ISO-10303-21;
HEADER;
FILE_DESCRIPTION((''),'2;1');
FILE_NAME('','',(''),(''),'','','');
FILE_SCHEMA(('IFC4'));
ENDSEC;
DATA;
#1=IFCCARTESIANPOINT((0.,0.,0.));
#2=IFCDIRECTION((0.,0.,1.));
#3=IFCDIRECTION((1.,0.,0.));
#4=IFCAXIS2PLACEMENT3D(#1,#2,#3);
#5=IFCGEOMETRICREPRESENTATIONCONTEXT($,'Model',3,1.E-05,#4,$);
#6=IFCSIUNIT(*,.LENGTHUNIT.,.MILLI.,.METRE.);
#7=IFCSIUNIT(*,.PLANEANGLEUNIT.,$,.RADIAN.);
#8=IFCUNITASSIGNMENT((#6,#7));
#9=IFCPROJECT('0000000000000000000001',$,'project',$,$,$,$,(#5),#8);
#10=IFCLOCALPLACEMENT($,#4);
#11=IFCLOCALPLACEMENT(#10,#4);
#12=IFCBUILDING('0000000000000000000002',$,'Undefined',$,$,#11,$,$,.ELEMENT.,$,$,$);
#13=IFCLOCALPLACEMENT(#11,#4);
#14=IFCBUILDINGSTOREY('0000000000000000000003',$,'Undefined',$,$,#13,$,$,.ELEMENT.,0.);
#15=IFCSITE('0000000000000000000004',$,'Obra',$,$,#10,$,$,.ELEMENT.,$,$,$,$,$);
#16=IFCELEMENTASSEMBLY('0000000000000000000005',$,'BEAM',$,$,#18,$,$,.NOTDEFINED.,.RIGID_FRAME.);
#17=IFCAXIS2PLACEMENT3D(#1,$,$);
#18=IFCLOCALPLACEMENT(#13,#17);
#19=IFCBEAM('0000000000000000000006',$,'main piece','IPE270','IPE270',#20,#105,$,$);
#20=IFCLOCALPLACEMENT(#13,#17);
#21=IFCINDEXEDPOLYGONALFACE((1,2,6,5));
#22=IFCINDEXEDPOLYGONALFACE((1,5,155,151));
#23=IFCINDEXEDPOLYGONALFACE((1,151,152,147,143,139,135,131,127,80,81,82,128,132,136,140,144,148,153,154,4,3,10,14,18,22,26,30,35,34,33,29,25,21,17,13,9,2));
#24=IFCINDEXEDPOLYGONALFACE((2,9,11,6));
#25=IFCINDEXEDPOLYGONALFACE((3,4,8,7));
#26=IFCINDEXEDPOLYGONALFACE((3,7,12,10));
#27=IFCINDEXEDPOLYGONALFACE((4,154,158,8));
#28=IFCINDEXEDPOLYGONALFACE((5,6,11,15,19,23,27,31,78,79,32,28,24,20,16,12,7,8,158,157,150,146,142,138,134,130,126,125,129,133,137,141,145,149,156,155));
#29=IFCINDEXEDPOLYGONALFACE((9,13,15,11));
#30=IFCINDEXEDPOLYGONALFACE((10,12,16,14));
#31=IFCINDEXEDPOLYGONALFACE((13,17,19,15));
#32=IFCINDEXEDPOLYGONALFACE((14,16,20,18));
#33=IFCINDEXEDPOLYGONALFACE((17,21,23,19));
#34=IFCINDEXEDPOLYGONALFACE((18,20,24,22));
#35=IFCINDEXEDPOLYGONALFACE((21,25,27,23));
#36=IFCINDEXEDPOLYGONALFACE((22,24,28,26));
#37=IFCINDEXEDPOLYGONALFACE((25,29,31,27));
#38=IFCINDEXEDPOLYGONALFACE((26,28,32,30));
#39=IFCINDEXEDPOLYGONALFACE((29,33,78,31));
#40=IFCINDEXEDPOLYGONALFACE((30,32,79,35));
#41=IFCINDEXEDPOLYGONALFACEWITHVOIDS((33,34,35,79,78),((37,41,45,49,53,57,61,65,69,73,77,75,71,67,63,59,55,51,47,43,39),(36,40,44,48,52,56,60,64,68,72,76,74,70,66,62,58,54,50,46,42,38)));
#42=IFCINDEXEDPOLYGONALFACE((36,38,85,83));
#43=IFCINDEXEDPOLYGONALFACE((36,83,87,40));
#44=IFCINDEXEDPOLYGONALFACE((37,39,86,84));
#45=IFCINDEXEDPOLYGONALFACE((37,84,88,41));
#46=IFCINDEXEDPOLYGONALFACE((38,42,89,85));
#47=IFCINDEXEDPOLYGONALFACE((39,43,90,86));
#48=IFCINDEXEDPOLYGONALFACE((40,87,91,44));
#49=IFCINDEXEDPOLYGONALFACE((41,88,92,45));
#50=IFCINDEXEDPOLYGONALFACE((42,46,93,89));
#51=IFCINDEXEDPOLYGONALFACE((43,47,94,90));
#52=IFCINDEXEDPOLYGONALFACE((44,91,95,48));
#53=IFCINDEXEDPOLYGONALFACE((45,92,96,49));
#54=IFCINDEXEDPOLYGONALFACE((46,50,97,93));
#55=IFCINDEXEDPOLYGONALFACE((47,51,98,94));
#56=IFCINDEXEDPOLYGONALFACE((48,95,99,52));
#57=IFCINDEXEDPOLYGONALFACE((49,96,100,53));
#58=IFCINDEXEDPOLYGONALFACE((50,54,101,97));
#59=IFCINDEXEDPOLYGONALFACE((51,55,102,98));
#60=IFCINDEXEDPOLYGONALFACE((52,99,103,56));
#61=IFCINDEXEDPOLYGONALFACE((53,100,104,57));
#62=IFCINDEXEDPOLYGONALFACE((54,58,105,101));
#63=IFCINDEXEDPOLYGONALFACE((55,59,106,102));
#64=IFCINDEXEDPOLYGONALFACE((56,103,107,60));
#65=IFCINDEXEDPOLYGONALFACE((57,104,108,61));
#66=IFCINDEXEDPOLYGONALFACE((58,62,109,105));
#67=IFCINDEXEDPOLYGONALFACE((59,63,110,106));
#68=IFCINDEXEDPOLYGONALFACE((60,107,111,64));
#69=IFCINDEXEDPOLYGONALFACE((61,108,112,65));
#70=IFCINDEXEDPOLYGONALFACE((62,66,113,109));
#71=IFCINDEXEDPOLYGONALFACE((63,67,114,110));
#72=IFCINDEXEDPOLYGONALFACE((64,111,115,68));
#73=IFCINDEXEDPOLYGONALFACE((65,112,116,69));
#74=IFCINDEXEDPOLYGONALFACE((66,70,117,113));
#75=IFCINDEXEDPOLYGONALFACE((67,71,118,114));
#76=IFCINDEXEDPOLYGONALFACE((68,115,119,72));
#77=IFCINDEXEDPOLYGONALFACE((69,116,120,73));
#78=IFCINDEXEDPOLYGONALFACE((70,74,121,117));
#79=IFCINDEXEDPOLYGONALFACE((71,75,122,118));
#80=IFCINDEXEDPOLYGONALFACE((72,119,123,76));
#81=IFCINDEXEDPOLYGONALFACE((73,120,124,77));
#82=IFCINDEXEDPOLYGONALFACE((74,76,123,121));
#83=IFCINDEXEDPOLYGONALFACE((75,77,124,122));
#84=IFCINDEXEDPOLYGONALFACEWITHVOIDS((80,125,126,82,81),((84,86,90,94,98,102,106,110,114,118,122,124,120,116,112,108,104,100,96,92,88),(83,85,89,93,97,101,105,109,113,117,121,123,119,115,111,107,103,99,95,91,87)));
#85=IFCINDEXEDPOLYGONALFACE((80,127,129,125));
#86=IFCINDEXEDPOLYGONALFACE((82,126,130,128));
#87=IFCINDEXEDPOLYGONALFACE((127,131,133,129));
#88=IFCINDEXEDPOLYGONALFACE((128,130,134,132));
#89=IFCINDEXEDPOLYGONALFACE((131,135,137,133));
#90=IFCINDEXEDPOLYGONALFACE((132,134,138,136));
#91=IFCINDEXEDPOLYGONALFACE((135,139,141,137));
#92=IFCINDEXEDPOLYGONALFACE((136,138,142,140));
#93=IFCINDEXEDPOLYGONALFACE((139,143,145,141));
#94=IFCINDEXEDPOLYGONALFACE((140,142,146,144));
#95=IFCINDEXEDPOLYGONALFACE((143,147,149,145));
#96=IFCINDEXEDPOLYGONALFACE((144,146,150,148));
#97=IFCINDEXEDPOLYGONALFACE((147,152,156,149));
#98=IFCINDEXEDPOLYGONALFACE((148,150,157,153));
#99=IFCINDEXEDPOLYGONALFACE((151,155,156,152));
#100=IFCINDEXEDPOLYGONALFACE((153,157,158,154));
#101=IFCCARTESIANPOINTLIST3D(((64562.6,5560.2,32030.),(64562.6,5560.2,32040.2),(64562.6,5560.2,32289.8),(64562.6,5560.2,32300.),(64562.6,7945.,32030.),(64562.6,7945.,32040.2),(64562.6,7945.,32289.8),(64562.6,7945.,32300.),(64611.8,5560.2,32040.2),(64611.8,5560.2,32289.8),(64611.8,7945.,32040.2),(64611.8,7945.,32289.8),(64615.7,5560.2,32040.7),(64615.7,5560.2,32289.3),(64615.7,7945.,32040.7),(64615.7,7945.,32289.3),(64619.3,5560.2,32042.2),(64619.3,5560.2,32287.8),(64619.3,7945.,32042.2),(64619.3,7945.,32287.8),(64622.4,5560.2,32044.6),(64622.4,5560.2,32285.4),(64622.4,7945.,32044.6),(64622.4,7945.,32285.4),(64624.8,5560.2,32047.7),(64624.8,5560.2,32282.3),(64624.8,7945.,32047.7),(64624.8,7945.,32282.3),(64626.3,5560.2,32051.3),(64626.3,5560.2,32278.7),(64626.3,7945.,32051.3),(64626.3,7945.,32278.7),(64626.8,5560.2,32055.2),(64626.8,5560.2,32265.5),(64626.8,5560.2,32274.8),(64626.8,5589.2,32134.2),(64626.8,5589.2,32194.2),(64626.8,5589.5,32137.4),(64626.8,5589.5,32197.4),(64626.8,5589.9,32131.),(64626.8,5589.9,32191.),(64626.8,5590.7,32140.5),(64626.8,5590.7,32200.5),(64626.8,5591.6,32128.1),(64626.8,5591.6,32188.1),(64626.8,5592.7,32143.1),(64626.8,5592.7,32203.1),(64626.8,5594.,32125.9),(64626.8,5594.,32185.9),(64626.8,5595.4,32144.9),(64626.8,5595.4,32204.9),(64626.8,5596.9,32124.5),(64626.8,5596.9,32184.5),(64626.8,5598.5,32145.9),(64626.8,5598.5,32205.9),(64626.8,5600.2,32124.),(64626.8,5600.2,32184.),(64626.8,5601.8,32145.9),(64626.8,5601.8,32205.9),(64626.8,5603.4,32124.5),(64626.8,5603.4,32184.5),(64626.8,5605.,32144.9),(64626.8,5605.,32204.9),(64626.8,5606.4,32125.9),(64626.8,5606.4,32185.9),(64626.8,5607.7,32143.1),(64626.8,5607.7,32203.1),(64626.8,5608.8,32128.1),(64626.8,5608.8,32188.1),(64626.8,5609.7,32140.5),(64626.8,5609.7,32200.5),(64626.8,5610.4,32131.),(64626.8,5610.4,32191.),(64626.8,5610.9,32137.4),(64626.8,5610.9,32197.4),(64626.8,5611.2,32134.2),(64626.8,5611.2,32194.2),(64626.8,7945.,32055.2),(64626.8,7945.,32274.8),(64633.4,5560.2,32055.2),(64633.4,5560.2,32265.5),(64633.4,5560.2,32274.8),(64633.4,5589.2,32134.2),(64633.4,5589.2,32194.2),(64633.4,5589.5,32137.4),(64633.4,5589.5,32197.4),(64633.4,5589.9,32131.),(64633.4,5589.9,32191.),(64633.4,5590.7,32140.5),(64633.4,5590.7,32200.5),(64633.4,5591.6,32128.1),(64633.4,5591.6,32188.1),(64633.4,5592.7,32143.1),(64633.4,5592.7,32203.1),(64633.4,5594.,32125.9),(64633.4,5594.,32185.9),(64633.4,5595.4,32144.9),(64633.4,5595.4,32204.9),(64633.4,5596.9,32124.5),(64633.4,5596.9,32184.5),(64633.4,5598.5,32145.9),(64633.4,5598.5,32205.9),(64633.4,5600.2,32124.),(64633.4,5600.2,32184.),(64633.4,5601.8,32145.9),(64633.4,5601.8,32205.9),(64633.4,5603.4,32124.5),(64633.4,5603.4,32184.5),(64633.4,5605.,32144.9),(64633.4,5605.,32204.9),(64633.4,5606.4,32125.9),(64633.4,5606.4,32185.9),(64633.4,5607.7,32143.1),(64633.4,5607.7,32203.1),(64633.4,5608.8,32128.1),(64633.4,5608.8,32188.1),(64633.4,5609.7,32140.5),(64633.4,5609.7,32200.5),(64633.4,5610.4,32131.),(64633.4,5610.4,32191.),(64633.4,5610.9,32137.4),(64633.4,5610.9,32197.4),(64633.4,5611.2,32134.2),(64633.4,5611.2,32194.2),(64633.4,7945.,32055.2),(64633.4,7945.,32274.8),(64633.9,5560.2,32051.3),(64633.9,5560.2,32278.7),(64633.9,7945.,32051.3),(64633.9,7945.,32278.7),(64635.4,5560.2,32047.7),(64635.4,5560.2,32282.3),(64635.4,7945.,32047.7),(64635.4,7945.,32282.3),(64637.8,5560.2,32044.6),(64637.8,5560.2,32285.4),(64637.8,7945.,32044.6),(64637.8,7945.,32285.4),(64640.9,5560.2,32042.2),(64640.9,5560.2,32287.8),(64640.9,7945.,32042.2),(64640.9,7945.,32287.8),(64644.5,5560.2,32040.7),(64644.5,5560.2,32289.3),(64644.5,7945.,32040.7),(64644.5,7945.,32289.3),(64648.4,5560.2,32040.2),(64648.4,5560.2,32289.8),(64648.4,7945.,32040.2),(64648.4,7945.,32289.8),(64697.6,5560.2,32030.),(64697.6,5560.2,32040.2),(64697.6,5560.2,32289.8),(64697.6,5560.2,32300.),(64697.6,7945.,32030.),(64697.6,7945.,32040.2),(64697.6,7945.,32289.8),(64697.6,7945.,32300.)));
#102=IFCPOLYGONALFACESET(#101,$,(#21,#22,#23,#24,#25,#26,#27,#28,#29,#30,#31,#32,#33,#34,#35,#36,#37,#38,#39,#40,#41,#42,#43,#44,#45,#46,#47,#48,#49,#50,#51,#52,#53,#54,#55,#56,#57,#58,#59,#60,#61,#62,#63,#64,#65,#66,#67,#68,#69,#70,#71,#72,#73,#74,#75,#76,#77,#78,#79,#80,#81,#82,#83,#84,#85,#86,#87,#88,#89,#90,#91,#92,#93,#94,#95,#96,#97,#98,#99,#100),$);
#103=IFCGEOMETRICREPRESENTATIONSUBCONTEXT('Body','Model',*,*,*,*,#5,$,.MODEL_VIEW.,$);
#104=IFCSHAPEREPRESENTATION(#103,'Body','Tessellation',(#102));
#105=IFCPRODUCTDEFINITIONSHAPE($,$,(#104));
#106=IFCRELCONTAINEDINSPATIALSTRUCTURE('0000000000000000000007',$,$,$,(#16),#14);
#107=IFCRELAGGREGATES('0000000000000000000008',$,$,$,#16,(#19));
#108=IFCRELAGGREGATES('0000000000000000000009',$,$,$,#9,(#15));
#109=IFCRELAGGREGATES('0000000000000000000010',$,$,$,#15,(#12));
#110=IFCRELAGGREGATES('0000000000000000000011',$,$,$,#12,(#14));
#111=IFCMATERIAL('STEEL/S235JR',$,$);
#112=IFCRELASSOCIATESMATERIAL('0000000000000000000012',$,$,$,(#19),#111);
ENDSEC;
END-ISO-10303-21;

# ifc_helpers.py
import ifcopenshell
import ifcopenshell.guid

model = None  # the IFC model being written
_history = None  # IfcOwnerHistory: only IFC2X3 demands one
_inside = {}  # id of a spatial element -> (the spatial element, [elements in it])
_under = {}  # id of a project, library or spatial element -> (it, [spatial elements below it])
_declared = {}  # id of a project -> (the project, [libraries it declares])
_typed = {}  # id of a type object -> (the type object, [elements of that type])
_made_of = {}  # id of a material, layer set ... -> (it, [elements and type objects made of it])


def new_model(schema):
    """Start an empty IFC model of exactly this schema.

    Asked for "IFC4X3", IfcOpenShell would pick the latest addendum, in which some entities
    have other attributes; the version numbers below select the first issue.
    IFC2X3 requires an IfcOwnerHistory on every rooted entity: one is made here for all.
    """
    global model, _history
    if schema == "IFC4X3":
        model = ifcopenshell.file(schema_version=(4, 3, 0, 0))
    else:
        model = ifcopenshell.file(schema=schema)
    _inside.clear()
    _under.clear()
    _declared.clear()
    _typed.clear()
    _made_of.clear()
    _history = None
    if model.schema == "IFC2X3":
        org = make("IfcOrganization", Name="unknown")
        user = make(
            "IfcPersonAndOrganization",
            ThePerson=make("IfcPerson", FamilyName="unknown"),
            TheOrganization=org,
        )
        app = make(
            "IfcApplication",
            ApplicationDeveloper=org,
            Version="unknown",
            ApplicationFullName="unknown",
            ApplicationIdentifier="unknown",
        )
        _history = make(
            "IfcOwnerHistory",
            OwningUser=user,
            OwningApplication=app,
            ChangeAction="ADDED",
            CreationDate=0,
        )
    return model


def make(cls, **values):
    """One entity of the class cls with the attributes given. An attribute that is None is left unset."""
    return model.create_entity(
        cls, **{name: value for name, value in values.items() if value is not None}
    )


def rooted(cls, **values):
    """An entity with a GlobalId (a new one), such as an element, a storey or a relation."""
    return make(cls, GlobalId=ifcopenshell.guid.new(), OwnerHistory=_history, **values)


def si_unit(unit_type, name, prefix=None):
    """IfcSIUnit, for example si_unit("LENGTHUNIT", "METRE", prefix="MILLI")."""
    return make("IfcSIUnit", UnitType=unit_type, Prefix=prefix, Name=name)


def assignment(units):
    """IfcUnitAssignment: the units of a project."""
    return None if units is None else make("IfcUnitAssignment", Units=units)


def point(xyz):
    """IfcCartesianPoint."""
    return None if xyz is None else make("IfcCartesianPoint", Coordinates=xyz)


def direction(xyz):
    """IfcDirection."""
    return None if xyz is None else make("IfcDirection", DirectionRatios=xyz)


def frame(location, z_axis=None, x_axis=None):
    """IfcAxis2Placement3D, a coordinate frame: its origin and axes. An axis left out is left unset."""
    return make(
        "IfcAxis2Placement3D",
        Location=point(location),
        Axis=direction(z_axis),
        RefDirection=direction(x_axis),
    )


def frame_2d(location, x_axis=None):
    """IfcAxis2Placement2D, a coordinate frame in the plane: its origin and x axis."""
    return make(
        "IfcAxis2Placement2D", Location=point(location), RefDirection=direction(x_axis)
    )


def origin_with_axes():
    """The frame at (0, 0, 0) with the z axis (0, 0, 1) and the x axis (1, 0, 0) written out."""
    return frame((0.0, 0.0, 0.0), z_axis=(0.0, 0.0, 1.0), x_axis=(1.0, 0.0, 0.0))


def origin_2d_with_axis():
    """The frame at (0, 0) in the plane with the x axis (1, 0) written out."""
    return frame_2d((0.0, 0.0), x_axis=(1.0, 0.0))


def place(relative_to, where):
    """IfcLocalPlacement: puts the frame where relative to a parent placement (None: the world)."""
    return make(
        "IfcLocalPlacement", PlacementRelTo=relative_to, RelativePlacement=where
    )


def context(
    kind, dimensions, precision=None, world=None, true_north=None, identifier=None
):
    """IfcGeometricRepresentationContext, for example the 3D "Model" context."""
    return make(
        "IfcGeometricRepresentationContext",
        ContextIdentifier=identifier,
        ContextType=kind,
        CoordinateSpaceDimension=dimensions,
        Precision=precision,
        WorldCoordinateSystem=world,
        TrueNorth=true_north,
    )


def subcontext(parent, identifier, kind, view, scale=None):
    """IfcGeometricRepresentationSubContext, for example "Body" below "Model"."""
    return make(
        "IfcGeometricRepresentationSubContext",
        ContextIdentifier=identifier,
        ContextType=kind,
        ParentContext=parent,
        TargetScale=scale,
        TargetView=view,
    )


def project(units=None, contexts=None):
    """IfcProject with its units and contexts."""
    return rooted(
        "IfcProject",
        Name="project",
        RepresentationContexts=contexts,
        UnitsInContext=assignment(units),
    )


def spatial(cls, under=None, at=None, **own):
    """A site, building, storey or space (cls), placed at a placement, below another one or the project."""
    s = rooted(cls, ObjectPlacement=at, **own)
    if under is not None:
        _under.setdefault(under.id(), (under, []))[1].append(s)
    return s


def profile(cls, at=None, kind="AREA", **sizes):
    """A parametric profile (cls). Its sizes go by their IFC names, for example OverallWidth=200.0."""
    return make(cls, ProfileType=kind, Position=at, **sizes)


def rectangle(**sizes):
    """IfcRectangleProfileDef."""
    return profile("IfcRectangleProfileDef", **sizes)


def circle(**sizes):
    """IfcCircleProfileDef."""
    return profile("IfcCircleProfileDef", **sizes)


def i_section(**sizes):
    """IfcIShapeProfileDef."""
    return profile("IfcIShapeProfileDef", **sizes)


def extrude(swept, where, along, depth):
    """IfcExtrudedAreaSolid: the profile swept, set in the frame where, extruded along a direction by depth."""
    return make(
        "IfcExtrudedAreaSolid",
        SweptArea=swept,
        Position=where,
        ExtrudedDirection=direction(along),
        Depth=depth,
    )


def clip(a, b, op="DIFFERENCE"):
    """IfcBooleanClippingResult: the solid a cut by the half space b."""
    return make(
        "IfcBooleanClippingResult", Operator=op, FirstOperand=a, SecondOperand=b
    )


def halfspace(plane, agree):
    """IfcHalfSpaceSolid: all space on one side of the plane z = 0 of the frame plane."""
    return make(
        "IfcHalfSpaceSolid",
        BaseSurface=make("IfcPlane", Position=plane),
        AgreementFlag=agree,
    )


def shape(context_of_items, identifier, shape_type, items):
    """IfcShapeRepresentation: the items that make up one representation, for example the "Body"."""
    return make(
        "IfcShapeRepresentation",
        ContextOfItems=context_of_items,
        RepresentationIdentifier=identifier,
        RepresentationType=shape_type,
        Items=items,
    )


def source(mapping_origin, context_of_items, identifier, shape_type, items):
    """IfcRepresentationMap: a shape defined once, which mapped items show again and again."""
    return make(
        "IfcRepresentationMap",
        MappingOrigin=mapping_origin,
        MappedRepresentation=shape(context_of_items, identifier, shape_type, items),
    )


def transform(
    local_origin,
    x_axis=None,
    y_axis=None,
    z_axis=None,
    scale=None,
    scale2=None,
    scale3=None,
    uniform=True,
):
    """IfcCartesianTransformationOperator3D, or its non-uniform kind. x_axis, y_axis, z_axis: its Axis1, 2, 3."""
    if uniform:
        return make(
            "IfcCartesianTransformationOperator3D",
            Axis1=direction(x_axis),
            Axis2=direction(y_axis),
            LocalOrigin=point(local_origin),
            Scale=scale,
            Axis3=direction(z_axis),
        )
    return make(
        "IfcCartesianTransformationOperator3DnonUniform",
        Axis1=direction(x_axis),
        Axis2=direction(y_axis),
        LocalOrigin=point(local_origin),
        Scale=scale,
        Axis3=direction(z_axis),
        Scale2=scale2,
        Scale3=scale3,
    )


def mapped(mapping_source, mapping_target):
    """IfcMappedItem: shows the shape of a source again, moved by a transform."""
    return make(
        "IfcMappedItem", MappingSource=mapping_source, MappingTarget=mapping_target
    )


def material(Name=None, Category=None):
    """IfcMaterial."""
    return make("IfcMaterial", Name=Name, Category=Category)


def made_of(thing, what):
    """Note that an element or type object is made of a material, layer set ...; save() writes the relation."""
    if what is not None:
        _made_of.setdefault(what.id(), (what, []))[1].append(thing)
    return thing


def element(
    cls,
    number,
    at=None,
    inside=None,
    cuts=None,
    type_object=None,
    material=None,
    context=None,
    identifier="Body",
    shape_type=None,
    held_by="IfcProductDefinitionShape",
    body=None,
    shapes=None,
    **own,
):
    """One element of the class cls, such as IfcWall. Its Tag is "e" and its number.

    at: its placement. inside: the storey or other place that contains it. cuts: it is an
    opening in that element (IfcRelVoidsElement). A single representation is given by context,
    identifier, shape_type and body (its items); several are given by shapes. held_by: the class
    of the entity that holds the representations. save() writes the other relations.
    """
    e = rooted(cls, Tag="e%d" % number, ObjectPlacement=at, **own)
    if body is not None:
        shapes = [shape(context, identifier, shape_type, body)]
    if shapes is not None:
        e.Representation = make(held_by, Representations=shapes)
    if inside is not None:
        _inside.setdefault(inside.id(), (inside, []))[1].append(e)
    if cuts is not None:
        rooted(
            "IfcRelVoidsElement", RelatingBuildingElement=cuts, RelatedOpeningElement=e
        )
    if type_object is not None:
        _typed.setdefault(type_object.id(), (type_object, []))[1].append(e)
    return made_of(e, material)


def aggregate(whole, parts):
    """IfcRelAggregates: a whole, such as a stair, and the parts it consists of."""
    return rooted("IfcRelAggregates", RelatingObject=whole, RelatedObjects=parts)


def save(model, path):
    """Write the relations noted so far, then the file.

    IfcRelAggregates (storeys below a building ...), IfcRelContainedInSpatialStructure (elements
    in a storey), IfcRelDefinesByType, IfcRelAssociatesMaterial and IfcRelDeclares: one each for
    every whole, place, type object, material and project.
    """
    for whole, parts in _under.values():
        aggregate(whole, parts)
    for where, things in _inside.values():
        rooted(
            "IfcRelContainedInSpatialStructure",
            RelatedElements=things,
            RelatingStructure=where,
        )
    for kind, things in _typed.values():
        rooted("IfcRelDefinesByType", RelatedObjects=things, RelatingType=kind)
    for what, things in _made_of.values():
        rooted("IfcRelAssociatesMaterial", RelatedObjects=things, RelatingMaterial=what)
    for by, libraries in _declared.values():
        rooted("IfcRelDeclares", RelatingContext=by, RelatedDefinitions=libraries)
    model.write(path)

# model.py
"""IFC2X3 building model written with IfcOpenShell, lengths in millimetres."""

from ifc_helpers import new_model, si_unit, frame, origin_with_axes, origin_2d_with_axis, place, context, subcontext, project, spatial, rectangle, circle, i_section, extrude, clip, halfspace, source, transform, mapped, material, element, aggregate, save


model = new_model("IFC2X3")

# Units and contexts
model_context = context("Model", 3, precision=1e-05, world=origin_with_axes())
body_context = subcontext(model_context, "Body", "Model", "MODEL_VIEW")
ifc_project = project(units=[si_unit("LENGTHUNIT", "METRE", prefix="MILLI"), si_unit("PLANEANGLEUNIT", "RADIAN")], contexts=[model_context])

# Site, building, storey
site_placement = place(None, origin_with_axes())
site = spatial("IfcSite", under=ifc_project, at=site_placement, Name="Obra", CompositionType="ELEMENT")
building_placement = place(site_placement, origin_with_axes())
building = spatial("IfcBuilding", under=site, at=building_placement, Name="Undefined", CompositionType="ELEMENT")
storey_placement = place(building_placement, origin_with_axes())
storey = spatial("IfcBuildingStorey", under=building, at=storey_placement, Name="Undefined", CompositionType="ELEMENT", Elevation=0.0)

# Shared definitions
ifc_material_1 = material(Name="STEEL/S235JR")

# Element assembly, beam, openings
shared_shape_1 = source(origin_with_axes(), body_context, "Body", "SweptSolid", [
    extrude(circle(Radius=11.0, at=origin_2d_with_axis()), frame((0.0, -3.4, 0.0), z_axis=(0.0, 1.0, 0.0), x_axis=(1.0, 0.0, 0.0)), (0.0, 0.0, 1.0), 6.8),
])
assembly_1_placement = place(storey_placement, origin_with_axes())
assembly_1 = element("IfcElementAssembly", 1, at=assembly_1_placement, inside=storey, Name="BEAM", AssemblyPlace="NOTDEFINED", PredefinedType="RIGID_FRAME")
beam_1_placement = place(assembly_1_placement, frame((64630.1, 7945.0, 32165.0), z_axis=(0.0, 0.0, 1.0), x_axis=(0.0, -1.0, 0.0)))
beam_1 = element("IfcBeam", 2, at=beam_1_placement, material=ifc_material_1, Name="main piece", Description="IPE270", ObjectType="IPE270", context=body_context, shape_type="Clipping", body=[
    clip(extrude(i_section(OverallWidth=135.0, OverallDepth=270.0, WebThickness=6.6, FlangeThickness=10.2, FilletRadius=15.0, at=origin_2d_with_axis()), frame((2384.8, 0.0, 0.0), z_axis=(-1.0, 0.0, 0.0), x_axis=(0.0, -1.0, 0.0)), (0.0, 0.0, 1.0), 2384.8), halfspace(frame((2384.8, 0.0, -235.0), z_axis=(-1.0, 0.0, 0.0), x_axis=(0.0, 1.0, 0.0)), True)),
])
opening_1_placement = place(assembly_1_placement, frame((64630.1, 7945.0, 32165.0), z_axis=(0.0, 0.0, 1.0), x_axis=(0.0, -1.0, 0.0)))
element("IfcOpeningElement", 3, at=opening_1_placement, cuts=beam_1, ObjectType="Recess", context=body_context, shape_type="SweptSolid", body=[
    extrude(rectangle(XDim=35.5, YDim=97.7, at=origin_2d_with_axis()), frame((2433.7, 68.5, 118.2), z_axis=(0.0, -1.0, 0.0), x_axis=(0.0, 0.0, -1.0)), (0.0, 0.0, 1.0), 137.0),
])
opening_2_placement = place(assembly_1_placement, frame((64630.1, 5560.2, 32235.0), z_axis=(0.0, 1.0, 0.0), x_axis=(0.0, 0.0, -1.0)))
element("IfcOpeningElement", 4, at=opening_2_placement, cuts=beam_1, ObjectType="Opening", context=body_context, shape_type="MappedRepresentation", body=[
    mapped(shared_shape_1, transform((40.0, 0.0, 40.0))),
    mapped(shared_shape_1, transform((100.0, 0.0, 40.0))),
])

aggregate(assembly_1, [beam_1])

save(model, "model.ifc")
